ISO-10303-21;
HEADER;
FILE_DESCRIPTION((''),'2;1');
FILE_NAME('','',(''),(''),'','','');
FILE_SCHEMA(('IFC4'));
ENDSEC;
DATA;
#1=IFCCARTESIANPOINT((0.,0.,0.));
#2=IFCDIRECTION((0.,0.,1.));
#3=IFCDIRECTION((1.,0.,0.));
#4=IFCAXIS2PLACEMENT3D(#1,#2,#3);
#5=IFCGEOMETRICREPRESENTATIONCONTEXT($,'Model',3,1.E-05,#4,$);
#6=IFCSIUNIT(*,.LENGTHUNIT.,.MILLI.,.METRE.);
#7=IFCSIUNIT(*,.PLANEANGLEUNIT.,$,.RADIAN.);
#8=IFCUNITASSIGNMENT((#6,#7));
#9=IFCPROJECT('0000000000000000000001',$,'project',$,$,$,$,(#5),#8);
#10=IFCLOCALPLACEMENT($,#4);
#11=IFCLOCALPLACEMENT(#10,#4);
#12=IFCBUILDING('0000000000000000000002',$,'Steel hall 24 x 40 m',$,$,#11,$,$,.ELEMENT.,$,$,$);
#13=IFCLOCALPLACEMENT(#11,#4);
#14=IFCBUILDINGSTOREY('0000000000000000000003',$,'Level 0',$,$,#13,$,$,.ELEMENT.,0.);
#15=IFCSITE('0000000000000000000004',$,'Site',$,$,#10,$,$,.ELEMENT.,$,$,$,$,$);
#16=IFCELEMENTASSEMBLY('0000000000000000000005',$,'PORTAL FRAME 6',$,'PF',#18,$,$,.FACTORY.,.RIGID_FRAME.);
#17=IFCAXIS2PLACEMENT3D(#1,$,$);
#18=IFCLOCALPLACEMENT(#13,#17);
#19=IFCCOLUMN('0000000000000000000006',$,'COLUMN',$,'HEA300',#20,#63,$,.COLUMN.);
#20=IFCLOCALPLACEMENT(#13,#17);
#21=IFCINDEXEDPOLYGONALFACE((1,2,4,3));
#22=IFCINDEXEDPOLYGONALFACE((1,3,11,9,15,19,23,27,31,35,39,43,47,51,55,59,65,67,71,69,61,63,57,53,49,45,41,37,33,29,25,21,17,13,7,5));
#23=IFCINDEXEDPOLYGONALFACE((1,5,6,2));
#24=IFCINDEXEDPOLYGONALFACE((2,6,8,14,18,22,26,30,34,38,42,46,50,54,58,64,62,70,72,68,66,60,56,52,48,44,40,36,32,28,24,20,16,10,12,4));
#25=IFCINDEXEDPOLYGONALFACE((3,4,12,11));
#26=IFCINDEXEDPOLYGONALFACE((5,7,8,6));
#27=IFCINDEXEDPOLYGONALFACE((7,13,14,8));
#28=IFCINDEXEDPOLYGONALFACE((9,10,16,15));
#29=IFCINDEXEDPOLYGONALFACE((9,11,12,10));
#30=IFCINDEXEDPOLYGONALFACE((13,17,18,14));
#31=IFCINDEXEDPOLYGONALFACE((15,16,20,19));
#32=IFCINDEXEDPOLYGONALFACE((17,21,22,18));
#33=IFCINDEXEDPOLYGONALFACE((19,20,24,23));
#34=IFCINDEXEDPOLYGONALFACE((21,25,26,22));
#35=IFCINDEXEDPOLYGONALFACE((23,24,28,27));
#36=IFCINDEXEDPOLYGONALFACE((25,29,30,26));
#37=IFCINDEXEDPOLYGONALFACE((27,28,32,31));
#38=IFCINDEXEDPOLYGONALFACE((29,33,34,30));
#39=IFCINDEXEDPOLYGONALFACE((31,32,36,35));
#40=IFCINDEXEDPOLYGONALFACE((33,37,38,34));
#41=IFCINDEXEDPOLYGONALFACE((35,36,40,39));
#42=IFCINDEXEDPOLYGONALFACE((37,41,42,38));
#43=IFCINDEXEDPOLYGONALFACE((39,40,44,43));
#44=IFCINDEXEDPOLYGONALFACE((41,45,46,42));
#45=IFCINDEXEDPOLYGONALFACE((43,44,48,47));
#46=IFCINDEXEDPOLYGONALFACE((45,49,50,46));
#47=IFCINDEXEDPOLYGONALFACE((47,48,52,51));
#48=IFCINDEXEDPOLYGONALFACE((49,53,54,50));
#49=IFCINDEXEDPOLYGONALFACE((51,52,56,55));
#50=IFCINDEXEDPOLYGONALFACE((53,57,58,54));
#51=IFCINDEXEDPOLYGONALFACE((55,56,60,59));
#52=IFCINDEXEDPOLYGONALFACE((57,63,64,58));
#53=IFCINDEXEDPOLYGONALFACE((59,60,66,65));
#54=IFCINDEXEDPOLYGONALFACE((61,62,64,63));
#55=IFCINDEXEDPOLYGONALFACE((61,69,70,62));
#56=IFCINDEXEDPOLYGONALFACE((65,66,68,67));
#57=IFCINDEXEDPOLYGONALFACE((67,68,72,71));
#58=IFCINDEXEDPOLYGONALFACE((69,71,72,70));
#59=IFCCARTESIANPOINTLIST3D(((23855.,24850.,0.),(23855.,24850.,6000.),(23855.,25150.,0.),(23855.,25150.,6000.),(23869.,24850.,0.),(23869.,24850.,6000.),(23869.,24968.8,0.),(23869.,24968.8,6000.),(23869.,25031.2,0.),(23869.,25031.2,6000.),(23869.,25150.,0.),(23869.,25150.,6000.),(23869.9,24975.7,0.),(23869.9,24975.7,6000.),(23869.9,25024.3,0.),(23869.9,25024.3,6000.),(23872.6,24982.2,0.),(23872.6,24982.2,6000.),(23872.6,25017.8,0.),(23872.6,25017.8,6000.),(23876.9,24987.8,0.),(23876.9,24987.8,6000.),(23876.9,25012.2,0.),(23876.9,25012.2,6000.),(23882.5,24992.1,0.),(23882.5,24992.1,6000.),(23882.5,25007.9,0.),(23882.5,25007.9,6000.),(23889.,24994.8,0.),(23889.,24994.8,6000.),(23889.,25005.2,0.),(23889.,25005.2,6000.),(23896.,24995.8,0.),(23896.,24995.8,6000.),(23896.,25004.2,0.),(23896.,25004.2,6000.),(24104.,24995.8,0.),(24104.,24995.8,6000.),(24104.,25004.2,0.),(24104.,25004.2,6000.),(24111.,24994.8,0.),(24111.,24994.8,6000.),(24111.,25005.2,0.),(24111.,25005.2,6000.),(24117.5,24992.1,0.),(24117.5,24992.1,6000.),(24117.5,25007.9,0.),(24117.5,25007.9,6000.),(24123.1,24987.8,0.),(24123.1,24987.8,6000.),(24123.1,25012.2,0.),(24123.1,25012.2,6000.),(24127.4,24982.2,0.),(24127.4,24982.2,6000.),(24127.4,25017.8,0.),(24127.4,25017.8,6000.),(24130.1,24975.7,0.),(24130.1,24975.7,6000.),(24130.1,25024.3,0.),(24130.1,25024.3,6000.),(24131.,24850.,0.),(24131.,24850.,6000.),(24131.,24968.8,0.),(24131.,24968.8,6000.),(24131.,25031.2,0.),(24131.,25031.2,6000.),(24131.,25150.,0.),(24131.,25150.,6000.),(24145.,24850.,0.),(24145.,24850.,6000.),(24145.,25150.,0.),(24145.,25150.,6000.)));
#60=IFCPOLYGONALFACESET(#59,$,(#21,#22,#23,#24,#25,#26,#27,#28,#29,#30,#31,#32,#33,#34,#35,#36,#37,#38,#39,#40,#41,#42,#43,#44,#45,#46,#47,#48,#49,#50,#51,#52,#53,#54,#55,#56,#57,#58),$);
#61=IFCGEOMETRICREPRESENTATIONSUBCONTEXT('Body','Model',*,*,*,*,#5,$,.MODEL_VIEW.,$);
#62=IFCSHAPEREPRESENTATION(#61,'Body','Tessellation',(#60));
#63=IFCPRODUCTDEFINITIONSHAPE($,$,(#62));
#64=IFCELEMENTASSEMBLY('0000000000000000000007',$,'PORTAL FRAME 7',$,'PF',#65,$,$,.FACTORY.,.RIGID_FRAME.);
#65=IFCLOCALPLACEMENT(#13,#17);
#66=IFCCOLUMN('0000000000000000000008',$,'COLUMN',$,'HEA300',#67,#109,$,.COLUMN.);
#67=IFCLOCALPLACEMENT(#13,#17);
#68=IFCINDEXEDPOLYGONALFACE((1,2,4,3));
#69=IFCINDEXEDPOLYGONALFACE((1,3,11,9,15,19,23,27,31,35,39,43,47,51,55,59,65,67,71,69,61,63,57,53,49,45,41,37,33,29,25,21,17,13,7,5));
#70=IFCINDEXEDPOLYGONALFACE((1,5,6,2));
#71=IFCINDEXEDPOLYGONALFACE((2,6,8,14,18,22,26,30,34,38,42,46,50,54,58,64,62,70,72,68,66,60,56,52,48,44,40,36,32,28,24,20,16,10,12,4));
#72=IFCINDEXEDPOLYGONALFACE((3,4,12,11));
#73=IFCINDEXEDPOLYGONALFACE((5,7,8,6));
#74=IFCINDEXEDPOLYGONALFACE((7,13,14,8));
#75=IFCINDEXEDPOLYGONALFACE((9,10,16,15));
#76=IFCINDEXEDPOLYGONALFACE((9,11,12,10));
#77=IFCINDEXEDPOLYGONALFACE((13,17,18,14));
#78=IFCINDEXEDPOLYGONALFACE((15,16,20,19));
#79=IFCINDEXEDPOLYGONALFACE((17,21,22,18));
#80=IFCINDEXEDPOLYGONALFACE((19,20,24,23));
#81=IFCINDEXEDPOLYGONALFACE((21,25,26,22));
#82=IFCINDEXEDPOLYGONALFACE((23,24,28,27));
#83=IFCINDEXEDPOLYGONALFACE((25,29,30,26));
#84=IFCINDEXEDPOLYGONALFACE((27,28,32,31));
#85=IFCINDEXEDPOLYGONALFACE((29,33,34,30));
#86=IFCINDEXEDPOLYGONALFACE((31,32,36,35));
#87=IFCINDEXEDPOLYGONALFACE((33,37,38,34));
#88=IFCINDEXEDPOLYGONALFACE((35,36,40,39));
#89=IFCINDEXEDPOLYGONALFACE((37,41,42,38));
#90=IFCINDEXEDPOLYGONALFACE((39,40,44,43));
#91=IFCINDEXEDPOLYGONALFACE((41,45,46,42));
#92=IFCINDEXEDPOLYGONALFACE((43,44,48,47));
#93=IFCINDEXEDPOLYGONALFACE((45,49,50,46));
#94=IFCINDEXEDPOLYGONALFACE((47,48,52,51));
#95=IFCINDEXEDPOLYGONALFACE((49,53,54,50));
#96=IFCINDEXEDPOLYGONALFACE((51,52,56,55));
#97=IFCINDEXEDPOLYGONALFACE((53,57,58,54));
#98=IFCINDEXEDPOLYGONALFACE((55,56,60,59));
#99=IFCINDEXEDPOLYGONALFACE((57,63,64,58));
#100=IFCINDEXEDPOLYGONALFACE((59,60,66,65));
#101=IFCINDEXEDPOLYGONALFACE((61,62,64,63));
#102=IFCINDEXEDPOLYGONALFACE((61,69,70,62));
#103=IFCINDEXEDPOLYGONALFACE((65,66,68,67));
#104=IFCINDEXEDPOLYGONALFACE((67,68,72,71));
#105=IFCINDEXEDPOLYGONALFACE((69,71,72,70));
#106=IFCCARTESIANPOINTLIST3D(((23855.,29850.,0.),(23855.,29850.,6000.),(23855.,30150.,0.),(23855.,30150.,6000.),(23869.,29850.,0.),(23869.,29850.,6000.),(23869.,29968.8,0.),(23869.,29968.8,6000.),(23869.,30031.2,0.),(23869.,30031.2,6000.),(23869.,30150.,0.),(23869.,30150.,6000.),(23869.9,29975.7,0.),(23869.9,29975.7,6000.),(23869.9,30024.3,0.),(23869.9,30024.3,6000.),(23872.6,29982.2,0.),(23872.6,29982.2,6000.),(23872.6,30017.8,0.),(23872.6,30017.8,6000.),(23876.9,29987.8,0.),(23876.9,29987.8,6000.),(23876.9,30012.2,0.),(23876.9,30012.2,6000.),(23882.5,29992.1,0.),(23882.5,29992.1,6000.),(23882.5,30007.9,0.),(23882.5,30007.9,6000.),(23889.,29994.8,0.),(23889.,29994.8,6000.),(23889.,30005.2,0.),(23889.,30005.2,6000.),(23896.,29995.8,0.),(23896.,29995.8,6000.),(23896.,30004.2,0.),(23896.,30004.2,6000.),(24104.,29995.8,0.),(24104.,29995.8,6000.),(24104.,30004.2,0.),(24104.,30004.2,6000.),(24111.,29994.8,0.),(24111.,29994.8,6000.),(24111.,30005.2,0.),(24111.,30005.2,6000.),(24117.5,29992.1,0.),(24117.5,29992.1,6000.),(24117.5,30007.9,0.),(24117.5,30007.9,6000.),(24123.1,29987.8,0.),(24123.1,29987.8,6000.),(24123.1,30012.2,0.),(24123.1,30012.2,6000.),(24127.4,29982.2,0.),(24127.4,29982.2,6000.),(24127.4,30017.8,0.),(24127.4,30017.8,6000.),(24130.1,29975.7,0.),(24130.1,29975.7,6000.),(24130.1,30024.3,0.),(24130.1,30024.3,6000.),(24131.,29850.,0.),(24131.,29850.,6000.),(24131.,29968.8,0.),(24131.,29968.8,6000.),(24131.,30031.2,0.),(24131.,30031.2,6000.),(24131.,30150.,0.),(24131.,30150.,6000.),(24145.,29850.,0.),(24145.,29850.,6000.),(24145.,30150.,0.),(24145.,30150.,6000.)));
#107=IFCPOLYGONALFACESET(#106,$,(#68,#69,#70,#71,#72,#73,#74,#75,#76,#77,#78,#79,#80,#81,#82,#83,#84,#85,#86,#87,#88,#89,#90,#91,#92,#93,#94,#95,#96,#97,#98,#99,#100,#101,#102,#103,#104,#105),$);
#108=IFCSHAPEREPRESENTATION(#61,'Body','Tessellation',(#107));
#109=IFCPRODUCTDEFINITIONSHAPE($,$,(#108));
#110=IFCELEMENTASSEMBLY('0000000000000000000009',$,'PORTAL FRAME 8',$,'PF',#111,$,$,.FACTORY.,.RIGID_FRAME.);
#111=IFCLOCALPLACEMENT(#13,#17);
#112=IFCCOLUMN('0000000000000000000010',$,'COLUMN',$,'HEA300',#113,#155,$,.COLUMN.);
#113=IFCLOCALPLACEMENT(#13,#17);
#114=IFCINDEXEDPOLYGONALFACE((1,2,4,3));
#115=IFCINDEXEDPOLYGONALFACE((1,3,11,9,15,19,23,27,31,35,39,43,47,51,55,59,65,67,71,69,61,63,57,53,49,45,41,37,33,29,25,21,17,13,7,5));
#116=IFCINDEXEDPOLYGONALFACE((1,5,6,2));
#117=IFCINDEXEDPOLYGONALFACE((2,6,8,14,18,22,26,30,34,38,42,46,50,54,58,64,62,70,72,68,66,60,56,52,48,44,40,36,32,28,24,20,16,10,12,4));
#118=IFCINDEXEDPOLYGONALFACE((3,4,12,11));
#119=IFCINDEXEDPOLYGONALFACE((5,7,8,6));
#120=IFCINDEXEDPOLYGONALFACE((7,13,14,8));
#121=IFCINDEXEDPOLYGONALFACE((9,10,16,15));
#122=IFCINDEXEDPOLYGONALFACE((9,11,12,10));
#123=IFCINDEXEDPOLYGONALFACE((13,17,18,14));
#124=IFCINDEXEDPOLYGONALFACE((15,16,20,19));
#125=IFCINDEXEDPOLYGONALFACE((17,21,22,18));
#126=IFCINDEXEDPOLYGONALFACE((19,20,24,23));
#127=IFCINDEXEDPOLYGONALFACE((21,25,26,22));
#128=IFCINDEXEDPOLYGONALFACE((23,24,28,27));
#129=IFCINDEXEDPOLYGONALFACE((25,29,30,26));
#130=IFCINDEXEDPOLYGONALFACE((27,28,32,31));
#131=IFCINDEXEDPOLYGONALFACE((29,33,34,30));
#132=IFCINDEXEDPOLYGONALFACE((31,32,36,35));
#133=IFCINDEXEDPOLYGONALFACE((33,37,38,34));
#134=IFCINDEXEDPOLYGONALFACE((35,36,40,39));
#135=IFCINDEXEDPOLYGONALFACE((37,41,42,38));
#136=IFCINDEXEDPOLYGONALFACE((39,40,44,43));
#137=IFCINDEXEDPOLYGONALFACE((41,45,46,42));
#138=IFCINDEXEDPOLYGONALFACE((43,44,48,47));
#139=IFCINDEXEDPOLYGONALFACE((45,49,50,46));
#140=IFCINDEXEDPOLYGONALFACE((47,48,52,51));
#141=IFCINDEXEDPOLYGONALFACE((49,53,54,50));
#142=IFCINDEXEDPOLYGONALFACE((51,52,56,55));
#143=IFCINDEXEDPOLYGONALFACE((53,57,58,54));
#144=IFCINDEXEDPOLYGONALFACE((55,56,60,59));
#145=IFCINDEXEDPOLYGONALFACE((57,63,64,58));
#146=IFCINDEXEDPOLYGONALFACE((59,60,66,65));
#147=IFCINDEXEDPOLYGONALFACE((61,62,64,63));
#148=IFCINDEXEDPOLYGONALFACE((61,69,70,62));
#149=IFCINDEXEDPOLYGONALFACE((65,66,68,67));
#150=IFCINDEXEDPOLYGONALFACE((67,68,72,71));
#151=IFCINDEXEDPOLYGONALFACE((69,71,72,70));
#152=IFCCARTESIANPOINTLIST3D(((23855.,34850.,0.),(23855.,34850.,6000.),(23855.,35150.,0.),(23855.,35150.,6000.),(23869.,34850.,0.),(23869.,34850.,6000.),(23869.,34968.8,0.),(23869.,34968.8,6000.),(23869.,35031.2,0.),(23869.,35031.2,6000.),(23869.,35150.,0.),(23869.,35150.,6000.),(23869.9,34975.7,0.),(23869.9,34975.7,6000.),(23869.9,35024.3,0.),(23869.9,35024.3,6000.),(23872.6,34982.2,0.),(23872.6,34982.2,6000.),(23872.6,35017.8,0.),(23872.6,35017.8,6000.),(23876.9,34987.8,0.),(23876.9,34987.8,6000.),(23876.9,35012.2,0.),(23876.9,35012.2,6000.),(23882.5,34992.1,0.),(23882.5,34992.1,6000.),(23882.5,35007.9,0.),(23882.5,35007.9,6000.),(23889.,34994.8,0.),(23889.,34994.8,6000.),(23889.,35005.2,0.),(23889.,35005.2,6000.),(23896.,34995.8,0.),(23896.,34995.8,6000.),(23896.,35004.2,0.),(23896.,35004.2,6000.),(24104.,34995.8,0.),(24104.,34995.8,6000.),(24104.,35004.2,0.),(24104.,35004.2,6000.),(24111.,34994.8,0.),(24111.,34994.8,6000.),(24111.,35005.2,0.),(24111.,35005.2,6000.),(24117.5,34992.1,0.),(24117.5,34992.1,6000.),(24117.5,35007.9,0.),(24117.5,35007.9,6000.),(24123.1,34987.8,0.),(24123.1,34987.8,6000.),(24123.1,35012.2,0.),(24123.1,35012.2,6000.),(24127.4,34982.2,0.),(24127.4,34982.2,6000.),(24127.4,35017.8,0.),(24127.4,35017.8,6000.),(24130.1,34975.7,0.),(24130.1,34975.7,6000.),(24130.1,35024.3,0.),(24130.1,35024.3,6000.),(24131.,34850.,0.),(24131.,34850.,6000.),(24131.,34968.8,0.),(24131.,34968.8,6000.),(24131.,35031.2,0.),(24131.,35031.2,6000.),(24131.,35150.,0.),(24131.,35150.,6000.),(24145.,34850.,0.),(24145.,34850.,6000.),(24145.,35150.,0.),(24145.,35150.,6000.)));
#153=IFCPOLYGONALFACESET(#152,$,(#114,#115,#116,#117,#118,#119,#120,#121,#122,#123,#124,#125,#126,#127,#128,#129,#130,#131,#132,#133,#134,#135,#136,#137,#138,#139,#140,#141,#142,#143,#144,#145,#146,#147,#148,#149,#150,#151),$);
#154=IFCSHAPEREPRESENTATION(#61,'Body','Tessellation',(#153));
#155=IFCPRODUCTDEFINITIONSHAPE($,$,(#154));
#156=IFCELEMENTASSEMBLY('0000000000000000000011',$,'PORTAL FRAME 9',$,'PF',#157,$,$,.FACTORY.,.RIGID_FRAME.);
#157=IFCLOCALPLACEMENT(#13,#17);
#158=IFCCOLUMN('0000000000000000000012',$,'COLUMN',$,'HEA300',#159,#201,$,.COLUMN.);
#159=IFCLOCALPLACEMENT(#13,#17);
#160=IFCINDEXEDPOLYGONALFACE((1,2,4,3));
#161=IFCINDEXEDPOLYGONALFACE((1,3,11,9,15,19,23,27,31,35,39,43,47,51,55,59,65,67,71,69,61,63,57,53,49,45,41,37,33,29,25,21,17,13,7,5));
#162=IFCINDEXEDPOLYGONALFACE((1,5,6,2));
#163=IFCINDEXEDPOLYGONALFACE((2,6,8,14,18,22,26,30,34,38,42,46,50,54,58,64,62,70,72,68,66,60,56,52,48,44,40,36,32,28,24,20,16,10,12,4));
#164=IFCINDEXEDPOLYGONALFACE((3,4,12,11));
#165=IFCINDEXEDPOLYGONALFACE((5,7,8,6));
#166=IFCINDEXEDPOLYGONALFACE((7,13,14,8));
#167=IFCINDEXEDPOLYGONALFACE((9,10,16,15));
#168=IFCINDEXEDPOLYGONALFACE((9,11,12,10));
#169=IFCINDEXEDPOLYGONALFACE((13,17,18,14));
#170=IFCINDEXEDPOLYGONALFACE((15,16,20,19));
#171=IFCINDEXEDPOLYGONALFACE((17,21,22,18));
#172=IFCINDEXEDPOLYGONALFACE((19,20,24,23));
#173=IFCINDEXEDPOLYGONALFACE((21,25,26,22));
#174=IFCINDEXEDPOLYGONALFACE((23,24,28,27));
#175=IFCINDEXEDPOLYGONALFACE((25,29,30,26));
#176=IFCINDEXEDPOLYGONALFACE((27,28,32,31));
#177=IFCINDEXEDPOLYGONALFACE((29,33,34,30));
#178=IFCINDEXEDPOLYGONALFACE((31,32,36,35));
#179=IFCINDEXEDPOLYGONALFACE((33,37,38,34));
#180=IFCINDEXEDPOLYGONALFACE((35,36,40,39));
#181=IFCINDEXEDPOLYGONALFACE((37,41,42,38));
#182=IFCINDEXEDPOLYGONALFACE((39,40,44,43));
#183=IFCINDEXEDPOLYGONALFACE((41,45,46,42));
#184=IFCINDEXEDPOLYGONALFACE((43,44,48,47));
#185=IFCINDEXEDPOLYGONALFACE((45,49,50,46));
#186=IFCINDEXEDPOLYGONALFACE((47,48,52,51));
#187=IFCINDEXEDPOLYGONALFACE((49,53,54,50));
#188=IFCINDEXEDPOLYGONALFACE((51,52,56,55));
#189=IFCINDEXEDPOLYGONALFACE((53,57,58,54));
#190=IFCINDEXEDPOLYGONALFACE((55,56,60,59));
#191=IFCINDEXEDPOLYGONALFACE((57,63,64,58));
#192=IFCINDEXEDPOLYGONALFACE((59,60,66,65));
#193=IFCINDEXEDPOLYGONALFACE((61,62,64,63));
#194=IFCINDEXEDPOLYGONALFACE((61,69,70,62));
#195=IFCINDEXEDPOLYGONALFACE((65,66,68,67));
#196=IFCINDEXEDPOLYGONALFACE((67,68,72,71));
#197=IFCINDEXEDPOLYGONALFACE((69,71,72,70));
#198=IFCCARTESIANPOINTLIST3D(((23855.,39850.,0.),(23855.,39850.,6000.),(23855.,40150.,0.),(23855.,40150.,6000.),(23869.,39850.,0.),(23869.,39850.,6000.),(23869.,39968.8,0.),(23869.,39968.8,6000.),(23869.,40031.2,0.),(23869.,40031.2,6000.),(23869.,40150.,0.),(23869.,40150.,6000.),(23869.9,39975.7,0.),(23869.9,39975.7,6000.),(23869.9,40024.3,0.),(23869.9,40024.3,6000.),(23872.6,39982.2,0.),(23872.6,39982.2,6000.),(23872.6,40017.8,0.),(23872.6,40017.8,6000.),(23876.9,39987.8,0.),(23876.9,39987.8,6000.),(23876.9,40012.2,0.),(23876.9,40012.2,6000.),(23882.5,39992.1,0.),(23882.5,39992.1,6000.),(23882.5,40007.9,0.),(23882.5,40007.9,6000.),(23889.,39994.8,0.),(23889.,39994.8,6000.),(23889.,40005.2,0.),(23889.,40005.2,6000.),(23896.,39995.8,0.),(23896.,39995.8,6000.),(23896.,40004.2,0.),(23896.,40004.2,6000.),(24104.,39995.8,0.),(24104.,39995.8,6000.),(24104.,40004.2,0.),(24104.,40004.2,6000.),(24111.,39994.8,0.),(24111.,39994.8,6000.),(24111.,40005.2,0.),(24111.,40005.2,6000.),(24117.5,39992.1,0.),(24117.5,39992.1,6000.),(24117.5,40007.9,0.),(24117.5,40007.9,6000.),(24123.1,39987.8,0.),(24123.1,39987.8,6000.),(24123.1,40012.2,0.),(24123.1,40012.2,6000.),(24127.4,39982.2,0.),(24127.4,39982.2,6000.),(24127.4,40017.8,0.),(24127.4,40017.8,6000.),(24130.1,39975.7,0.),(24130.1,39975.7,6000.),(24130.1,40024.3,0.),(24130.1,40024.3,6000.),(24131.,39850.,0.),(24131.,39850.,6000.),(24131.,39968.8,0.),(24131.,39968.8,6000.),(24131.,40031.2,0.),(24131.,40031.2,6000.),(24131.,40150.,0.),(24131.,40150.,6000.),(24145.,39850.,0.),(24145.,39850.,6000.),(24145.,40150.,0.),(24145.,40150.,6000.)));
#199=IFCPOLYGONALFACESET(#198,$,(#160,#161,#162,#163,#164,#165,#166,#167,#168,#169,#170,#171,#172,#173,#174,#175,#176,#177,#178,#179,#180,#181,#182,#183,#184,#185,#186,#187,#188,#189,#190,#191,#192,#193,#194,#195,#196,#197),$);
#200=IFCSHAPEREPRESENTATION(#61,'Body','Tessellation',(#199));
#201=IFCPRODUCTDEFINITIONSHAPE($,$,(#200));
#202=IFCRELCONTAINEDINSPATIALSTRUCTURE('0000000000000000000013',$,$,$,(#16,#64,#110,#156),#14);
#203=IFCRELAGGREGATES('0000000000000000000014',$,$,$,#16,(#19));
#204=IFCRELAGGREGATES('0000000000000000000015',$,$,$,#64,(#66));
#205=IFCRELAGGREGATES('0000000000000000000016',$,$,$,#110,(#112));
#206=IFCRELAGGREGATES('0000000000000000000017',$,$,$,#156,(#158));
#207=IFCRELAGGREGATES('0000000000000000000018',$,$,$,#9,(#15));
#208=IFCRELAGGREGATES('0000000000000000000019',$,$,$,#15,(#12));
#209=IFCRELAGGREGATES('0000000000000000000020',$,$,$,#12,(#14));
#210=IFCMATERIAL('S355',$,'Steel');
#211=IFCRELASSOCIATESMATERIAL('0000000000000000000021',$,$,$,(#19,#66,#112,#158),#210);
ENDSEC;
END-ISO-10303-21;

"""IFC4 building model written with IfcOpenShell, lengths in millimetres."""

from ifc_helpers import new_model, si_unit, frame, origin_with_axes, place, context, subcontext, project, spatial, i_section, extrude, material, element, aggregate, save


model = new_model("IFC4")

# Units and contexts
model_context = context("Model", 3, precision=1e-05, world=origin_with_axes())
body_context = subcontext(model_context, "Body", "Model", "MODEL_VIEW")
ifc_project = project(units=[si_unit("LENGTHUNIT", "METRE", prefix="MILLI"), si_unit("PLANEANGLEUNIT", "RADIAN")], contexts=[model_context])

# Site, building, storey
site_placement = place(None, origin_with_axes())
site = spatial("IfcSite", under=ifc_project, at=site_placement, Name="Site", CompositionType="ELEMENT")
building_placement = place(site_placement, origin_with_axes())
building = spatial("IfcBuilding", under=site, at=building_placement, Name="Steel hall 24 x 40 m", CompositionType="ELEMENT")
storey_placement = place(building_placement, origin_with_axes())
storey = spatial("IfcBuildingStorey", under=building, at=storey_placement, Name="Level 0", CompositionType="ELEMENT", Elevation=0.0)

# Element assemblies, columns
assembly_1_placement = place(storey_placement, frame((0.0, 25000.0, 0.0), z_axis=(0.0, 0.0, 1.0), x_axis=(1.0, 0.0, 0.0)))
assembly_1 = element("IfcElementAssembly", 1, at=assembly_1_placement, inside=storey, Name="PORTAL FRAME 6", ObjectType="PF", AssemblyPlace="FACTORY", PredefinedType="RIGID_FRAME")
ifc_material = material(Name="S355", Category="Steel")
column_1_placement = place(storey_placement, frame((24000.0, 25000.0, 0.0), z_axis=(0.0, 0.0, 1.0), x_axis=(0.0, 1.0, 0.0)))
column_1 = element("IfcColumn", 2, at=column_1_placement, material=ifc_material, Name="COLUMN", ObjectType="HEA300", PredefinedType="COLUMN", context=body_context, shape_type="SweptSolid", body=[
    extrude(i_section(OverallWidth=300.0, OverallDepth=290.0, WebThickness=8.5, FlangeThickness=14.0, FilletRadius=27.0), origin_with_axes(), (0.0, 0.0, 1.0), 6000.0),
])
assembly_2_placement = place(storey_placement, frame((0.0, 30000.0, 0.0), z_axis=(0.0, 0.0, 1.0), x_axis=(1.0, 0.0, 0.0)))
assembly_2 = element("IfcElementAssembly", 3, at=assembly_2_placement, inside=storey, Name="PORTAL FRAME 7", ObjectType="PF", AssemblyPlace="FACTORY", PredefinedType="RIGID_FRAME")
column_2_placement = place(storey_placement, frame((24000.0, 30000.0, 0.0), z_axis=(0.0, 0.0, 1.0), x_axis=(0.0, 1.0, 0.0)))
column_2 = element("IfcColumn", 4, at=column_2_placement, material=ifc_material, Name="COLUMN", ObjectType="HEA300", PredefinedType="COLUMN", context=body_context, shape_type="SweptSolid", body=[
    extrude(i_section(OverallWidth=300.0, OverallDepth=290.0, WebThickness=8.5, FlangeThickness=14.0, FilletRadius=27.0), origin_with_axes(), (0.0, 0.0, 1.0), 6000.0),
])
assembly_3_placement = place(storey_placement, frame((0.0, 35000.0, 0.0), z_axis=(0.0, 0.0, 1.0), x_axis=(1.0, 0.0, 0.0)))
assembly_3 = element("IfcElementAssembly", 5, at=assembly_3_placement, inside=storey, Name="PORTAL FRAME 8", ObjectType="PF", AssemblyPlace="FACTORY", PredefinedType="RIGID_FRAME")
column_3_placement = place(storey_placement, frame((24000.0, 35000.0, 0.0), z_axis=(0.0, 0.0, 1.0), x_axis=(0.0, 1.0, 0.0)))
column_3 = element("IfcColumn", 6, at=column_3_placement, material=ifc_material, Name="COLUMN", ObjectType="HEA300", PredefinedType="COLUMN", context=body_context, shape_type="SweptSolid", body=[
    extrude(i_section(OverallWidth=300.0, OverallDepth=290.0, WebThickness=8.5, FlangeThickness=14.0, FilletRadius=27.0), origin_with_axes(), (0.0, 0.0, 1.0), 6000.0),
])
assembly_4_placement = place(storey_placement, frame((0.0, 40000.0, 0.0), z_axis=(0.0, 0.0, 1.0), x_axis=(1.0, 0.0, 0.0)))
assembly_4 = element("IfcElementAssembly", 7, at=assembly_4_placement, inside=storey, Name="PORTAL FRAME 9", ObjectType="PF", AssemblyPlace="FACTORY", PredefinedType="RIGID_FRAME")
column_4_placement = place(storey_placement, frame((24000.0, 40000.0, 0.0), z_axis=(0.0, 0.0, 1.0), x_axis=(0.0, 1.0, 0.0)))
column_4 = element("IfcColumn", 8, at=column_4_placement, material=ifc_material, Name="COLUMN", ObjectType="HEA300", PredefinedType="COLUMN", context=body_context, shape_type="SweptSolid", body=[
    extrude(i_section(OverallWidth=300.0, OverallDepth=290.0, WebThickness=8.5, FlangeThickness=14.0, FilletRadius=27.0), origin_with_axes(), (0.0, 0.0, 1.0), 6000.0),
])

aggregate(assembly_1, [column_1])
aggregate(assembly_2, [column_2])
aggregate(assembly_3, [column_3])
aggregate(assembly_4, [column_4])

save(model, "model.ifc")
